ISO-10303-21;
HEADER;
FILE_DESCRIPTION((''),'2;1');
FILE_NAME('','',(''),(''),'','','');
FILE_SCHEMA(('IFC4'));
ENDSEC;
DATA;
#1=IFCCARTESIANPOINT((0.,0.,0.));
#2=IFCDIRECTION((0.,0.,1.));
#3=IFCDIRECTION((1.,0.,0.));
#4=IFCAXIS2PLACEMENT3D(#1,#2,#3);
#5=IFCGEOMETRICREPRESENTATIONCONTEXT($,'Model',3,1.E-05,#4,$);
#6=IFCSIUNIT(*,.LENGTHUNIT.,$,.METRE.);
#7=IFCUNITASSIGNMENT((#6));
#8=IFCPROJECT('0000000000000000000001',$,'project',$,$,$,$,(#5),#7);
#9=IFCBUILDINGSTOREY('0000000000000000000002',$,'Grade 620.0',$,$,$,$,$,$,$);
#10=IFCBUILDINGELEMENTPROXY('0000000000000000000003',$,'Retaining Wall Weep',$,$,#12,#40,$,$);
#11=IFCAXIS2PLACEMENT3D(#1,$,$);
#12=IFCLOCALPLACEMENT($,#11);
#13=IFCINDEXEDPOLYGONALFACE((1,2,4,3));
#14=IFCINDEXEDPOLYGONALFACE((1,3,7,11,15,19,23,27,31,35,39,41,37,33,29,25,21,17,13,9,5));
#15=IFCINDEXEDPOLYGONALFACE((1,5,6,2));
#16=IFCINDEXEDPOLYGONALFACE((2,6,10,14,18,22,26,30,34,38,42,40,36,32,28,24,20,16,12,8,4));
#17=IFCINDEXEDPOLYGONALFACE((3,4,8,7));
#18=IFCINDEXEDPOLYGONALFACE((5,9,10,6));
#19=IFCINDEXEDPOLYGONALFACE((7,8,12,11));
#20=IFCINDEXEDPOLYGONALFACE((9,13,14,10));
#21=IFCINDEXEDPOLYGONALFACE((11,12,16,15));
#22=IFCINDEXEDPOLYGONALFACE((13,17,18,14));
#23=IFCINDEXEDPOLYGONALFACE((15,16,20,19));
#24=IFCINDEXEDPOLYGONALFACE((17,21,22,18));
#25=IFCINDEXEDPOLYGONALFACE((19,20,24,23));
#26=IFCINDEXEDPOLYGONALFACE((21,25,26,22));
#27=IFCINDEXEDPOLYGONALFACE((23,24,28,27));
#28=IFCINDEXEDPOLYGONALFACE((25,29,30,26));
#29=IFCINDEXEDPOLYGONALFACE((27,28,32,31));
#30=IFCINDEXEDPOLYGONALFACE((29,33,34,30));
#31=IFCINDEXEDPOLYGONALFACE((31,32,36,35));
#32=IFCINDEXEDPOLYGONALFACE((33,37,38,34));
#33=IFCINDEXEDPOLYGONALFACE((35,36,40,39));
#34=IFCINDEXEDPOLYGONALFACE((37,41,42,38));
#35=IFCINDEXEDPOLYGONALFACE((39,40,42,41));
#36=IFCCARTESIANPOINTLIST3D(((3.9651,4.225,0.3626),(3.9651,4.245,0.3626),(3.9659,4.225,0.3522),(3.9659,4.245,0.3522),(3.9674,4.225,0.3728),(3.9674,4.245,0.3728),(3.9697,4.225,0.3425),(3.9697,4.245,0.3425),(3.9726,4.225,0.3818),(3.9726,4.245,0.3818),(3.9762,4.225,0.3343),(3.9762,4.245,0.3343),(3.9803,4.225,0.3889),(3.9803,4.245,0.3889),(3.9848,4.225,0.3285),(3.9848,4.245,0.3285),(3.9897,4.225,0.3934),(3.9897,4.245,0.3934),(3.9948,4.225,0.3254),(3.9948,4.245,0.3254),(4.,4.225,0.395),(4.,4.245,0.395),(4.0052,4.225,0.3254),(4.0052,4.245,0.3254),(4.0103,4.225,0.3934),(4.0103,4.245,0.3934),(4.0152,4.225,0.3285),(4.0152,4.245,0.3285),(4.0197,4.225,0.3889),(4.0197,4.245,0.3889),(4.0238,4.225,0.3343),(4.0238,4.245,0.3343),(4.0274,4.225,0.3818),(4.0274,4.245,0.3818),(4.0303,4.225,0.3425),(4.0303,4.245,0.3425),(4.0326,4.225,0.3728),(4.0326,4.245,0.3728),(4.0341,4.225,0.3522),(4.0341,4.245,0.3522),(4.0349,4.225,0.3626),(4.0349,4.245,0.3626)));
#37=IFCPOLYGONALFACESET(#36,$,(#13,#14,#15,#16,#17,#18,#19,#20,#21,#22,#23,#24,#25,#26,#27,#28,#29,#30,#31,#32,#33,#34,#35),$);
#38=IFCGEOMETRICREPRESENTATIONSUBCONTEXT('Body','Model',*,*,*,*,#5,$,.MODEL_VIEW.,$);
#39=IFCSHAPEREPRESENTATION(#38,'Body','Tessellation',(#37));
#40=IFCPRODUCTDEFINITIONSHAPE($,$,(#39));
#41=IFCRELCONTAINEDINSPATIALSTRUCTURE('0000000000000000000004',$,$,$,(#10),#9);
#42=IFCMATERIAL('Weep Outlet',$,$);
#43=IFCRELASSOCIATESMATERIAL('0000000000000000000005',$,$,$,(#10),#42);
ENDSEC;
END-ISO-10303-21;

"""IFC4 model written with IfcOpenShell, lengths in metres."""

from ifc_helpers import new_model, si_unit, frame, origin_with_axes, place, context, subcontext, project, spatial, circle, extrude, material, element, save


model = new_model("IFC4")

# Units and contexts
model_context = context("Model", 3, precision=1e-05, world=origin_with_axes())
body_context = subcontext(model_context, "Body", "Model", "MODEL_VIEW")
ifc_project = project(units=[si_unit("LENGTHUNIT", "METRE")], contexts=[model_context])

# Storey
storey = spatial("IfcBuildingStorey", Name="Grade 620.0")

# Building element proxy
ifc_material_1 = material(Name="Weep Outlet")
for number, where, z_axis, x_axis, name in (
    (1, (4.0, 4.225, 0.36), (0.0, 1.0, 0.0), (0.0, 0.0, 1.0), "Retaining Wall Weep"),
):
    element("IfcBuildingElementProxy", number, at=place(None, frame(where, z_axis=z_axis, x_axis=x_axis)), inside=storey, material=ifc_material_1, Name=name, context=body_context, shape_type="SweptSolid", body=[
        extrude(circle(Radius=0.035), origin_with_axes(), (0.0, 0.0, 1.0), 0.02),
    ])

save(model, "model.ifc")
